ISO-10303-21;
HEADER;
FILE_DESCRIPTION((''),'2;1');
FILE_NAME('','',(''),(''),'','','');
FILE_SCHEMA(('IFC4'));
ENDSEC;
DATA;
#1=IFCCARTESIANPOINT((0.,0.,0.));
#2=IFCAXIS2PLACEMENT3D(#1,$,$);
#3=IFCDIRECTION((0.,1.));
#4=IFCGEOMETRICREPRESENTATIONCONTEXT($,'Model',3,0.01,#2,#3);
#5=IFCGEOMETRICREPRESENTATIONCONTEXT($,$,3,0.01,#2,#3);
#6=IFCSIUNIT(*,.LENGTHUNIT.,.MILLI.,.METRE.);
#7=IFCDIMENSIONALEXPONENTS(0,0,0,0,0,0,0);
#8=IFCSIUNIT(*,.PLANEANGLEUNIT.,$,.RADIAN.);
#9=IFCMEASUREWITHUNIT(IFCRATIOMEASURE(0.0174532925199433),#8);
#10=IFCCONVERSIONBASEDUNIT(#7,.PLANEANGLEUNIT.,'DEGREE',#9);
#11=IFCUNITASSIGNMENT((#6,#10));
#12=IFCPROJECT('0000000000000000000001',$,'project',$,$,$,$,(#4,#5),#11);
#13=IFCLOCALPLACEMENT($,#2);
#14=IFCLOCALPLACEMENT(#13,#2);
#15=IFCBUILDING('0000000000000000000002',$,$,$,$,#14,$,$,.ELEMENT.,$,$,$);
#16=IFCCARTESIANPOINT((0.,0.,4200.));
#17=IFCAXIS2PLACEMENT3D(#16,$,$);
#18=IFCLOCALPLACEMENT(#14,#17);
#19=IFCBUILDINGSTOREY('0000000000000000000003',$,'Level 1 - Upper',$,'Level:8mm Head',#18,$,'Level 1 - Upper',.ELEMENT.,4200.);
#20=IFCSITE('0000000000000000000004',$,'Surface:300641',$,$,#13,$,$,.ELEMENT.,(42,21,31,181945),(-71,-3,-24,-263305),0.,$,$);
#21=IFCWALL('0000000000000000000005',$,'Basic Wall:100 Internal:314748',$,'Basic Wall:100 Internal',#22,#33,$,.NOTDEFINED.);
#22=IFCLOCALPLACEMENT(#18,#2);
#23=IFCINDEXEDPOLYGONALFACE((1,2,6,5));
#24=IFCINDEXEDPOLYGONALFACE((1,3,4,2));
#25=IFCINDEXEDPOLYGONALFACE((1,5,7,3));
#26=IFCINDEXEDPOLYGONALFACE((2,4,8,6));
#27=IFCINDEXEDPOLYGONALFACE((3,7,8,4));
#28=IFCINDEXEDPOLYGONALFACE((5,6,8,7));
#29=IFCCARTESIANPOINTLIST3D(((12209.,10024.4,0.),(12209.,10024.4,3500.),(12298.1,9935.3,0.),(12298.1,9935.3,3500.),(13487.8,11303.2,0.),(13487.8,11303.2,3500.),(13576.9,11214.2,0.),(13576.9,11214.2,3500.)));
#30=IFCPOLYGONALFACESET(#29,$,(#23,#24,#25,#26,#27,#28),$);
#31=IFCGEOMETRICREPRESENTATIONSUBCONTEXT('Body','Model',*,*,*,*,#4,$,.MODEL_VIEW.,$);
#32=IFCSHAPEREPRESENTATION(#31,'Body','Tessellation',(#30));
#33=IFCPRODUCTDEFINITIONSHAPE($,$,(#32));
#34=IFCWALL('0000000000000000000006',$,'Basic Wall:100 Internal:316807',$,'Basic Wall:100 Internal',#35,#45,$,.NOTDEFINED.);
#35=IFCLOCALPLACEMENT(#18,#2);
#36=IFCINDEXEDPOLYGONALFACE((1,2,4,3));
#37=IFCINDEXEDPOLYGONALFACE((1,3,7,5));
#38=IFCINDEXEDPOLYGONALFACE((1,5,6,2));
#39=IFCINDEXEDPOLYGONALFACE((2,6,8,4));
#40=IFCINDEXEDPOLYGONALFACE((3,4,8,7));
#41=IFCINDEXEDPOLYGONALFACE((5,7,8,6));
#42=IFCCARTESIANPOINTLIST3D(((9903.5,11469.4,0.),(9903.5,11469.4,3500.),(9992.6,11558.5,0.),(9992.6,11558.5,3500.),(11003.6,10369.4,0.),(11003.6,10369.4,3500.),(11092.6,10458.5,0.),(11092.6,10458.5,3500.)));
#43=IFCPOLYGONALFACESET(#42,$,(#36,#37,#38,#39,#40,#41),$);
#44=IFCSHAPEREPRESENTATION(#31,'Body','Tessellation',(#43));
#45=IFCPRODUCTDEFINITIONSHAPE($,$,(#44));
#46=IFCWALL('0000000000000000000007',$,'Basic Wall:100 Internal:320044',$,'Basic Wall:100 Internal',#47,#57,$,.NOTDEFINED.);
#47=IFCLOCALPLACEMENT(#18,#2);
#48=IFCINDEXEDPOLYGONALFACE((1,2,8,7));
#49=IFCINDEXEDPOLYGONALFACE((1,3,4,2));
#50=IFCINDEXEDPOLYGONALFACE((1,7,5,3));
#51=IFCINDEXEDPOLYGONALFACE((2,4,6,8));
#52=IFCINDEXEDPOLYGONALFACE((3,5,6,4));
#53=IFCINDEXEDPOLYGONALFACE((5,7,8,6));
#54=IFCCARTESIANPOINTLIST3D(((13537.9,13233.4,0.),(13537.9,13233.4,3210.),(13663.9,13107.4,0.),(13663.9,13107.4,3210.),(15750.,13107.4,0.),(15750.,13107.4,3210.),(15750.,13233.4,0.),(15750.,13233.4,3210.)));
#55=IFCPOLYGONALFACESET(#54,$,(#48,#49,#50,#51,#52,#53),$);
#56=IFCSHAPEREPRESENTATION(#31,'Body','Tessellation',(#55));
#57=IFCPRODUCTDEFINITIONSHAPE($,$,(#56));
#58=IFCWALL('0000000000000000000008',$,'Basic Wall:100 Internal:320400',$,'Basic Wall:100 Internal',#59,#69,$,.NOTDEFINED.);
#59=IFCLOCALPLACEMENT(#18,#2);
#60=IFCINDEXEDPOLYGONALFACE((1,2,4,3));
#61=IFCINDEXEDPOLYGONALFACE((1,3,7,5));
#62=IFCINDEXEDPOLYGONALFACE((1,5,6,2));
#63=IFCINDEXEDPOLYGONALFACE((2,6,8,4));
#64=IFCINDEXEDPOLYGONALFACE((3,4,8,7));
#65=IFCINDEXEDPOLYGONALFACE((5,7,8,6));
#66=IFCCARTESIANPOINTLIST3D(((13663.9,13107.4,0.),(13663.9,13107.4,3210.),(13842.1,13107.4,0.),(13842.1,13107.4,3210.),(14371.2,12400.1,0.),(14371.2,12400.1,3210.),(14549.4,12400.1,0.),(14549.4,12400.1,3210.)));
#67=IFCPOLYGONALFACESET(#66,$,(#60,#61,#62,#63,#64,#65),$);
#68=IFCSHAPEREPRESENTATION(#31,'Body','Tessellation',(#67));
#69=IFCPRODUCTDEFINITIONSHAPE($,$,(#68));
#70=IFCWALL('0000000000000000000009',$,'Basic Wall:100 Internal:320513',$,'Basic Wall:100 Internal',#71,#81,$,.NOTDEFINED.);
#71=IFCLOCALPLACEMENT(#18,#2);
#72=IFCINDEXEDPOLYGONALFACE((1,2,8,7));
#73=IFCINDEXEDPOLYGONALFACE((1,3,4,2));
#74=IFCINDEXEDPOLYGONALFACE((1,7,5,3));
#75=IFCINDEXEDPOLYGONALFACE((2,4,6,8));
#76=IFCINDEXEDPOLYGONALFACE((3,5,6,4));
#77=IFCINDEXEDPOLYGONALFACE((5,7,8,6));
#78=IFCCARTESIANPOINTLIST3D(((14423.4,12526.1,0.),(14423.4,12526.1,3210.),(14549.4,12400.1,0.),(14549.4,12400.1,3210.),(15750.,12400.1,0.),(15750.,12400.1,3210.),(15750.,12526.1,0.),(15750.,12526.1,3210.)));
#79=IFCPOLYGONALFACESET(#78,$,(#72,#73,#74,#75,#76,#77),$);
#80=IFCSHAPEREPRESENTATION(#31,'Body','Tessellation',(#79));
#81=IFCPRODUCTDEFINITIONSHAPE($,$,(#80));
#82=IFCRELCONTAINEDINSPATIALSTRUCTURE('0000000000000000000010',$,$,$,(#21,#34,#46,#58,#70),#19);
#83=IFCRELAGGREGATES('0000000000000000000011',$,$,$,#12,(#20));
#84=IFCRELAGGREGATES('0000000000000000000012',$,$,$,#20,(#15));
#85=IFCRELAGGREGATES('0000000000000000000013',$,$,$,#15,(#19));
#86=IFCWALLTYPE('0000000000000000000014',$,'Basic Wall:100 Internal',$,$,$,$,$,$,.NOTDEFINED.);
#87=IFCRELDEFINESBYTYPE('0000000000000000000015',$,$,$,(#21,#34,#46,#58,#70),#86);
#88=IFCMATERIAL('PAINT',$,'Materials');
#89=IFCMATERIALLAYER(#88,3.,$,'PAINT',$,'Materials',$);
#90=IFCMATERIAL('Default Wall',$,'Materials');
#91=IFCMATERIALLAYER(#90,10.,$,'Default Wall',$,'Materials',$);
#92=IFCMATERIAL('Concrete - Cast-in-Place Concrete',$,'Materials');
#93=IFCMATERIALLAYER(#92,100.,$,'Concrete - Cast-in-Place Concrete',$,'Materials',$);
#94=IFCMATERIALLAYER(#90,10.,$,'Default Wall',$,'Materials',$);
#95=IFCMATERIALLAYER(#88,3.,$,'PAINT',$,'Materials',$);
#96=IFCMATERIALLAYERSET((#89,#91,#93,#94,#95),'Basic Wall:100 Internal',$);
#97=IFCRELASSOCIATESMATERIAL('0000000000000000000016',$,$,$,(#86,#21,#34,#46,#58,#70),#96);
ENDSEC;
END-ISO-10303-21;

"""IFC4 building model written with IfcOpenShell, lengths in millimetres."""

from ifc_helpers import new_model, entity, si_unit, converted_unit, direction, frame, frame_2d, origin, place, context, subcontext, project, spatial, polyline, rectangle, outline, extrude, clip, halfspace, bounded_halfspace, material, layer, layer_set, layer_usage, type_object, element, save


model = new_model("IFC4")

# Units and contexts
model_context = context("Model", 3, precision=0.01, world=origin(), true_north=direction((0.0, 1.0)))
context_of_model = context(None, 3, precision=0.01, world=origin(), true_north=direction((0.0, 1.0)))
body_context = subcontext(model_context, "Body", "Model", "MODEL_VIEW")
ifc_project = project(units=[si_unit("LENGTHUNIT", "METRE", prefix="MILLI"), converted_unit("PLANEANGLEUNIT", "DEGREE", entity("IfcRatioMeasure", 0.0174532925199433), si_unit("PLANEANGLEUNIT", "RADIAN"), dimensions=[0, 0, 0, 0, 0, 0, 0])], contexts=[model_context, context_of_model])

# Site, building, storey
site_placement = place(None, origin())
site = spatial("IfcSite", under=ifc_project, at=site_placement, Name="Surface:300641", CompositionType="ELEMENT", RefLatitude=(42, 21, 31, 181945), RefLongitude=(-71, -3, -24, -263305), RefElevation=0.0)
building_placement = place(site_placement, origin())
building = spatial("IfcBuilding", under=site, at=building_placement, CompositionType="ELEMENT")
storey_placement = place(building_placement, frame((0.0, 0.0, 4200.0)))
storey = spatial("IfcBuildingStorey", under=building, at=storey_placement, Name="Level 1 - Upper", ObjectType="Level:8mm Head", LongName="Level 1 - Upper", CompositionType="ELEMENT", Elevation=4200.0)

# Shared definitions
ifc_material_1 = material(Name="PAINT", Category="Materials")
ifc_material_2 = material(Name="Concrete - Cast-in-Place Concrete", Category="Materials")
ifc_material_3 = material(Name="Default Wall", Category="Materials")

# Walls
ifc_layer_1 = layer(ifc_material_1, 3.0, Name="PAINT", Category="Materials")
ifc_layer_2 = layer(ifc_material_3, 10.0, Name="Default Wall", Category="Materials")
ifc_layer_3 = layer(ifc_material_2, 100.0, Name="Concrete - Cast-in-Place Concrete", Category="Materials")
ifc_layer_4 = layer(ifc_material_3, 10.0, Name="Default Wall", Category="Materials")
ifc_layer_5 = layer(ifc_material_1, 3.0, Name="PAINT", Category="Materials")
ifc_layer_set_1 = layer_set([ifc_layer_1, ifc_layer_2, ifc_layer_3, ifc_layer_4, ifc_layer_5], Name="Basic Wall:100 Internal")
ifc_layer_usage_1 = layer_usage(ifc_layer_set_1, "AXIS2", "NEGATIVE", 63.0)
wall_type_1 = type_object("IfcWallType", Name="Basic Wall:100 Internal", PredefinedType="NOTDEFINED", material=ifc_layer_set_1)
wall_1_placement = place(storey_placement, frame((13532.4, 11258.7, 0.0), z_axis=(0.0, 0.0, 1.0), x_axis=(-0.707107, -0.707107, 0.0)))
element("IfcWall", 1, at=wall_1_placement, inside=storey, type_object=wall_type_1, material=ifc_layer_usage_1, Name="Basic Wall:100 Internal:314748", ObjectType="Basic Wall:100 Internal", PredefinedType="NOTDEFINED", context=body_context, shape_type="Clipping", body=[
    clip(extrude(rectangle(XDim=1808.6, YDim=126.0, at=frame_2d((904.3, 0.0), x_axis=(-1.0, 0.0))), origin(), (0.0, 0.0, 1.0), 3500.0), halfspace(origin(), True)),
])
ifc_layer_usage_2 = layer_usage(ifc_layer_set_1, "AXIS2", "NEGATIVE", 63.0)
wall_2_placement = place(storey_placement, frame((9948.0, 11514.0, 0.0), z_axis=(0.0, 0.0, 1.0), x_axis=(0.707107, -0.707107, 0.0)))
element("IfcWall", 2, at=wall_2_placement, inside=storey, type_object=wall_type_1, material=ifc_layer_usage_2, Name="Basic Wall:100 Internal:316807", ObjectType="Basic Wall:100 Internal", PredefinedType="NOTDEFINED", context=body_context, shape_type="Clipping", body=[
    clip(extrude(rectangle(XDim=1555.7, YDim=126.0, at=frame_2d((777.9, 0.0), x_axis=(-1.0, 0.0))), origin(), (0.0, 0.0, 1.0), 3500.0), halfspace(origin(), True)),
])

# Walls
ifc_layer_usage_3 = layer_usage(ifc_layer_set_1, "AXIS2", "NEGATIVE", 63.0)
wall_3_placement = place(storey_placement, frame((15750.0, 13170.4, 0.0), z_axis=(0.0, 0.0, 1.0), x_axis=(-1.0, 0.0, 0.0)))
element("IfcWall", 3, at=wall_3_placement, inside=storey, type_object=wall_type_1, material=ifc_layer_usage_3, Name="Basic Wall:100 Internal:320044", ObjectType="Basic Wall:100 Internal", PredefinedType="NOTDEFINED", context=body_context, shape_type="Clipping", body=[
    clip(clip(extrude(outline(polyline([(2212.1, -63.0), (2086.1, 63.0), (1907.9, 63.0), (0.0, 63.0), (0.0, -63.0), (2212.1, -63.0)])), origin(), (0.0, 0.0, 1.0), 3210.0), bounded_halfspace(frame((0.0, -63.0, 3210.0), z_axis=(0.0, 0.0, -1.0), x_axis=(0.0, 1.0, 0.0)), True, frame((0.0, -63.0, 3210.0)), polyline([(0.0, 0.0), (2212.1, 0.0), (2086.1, 126.0), (1907.9, 126.0), (0.0, 126.0), (0.0, 0.0)]))), halfspace(frame((0.0, 0.0, -400.0)), True)),
])
ifc_layer_usage_4 = layer_usage(ifc_layer_set_1, "AXIS2", "NEGATIVE", 63.0)
wall_4_placement = place(storey_placement, frame((13708.5, 13152.0, 0.0), z_axis=(0.0, 0.0, 1.0), x_axis=(0.707107, -0.707107, 0.0)))
element("IfcWall", 4, at=wall_4_placement, inside=storey, type_object=wall_type_1, material=ifc_layer_usage_4, Name="Basic Wall:100 Internal:320400", ObjectType="Basic Wall:100 Internal", PredefinedType="NOTDEFINED", context=body_context, shape_type="Clipping", body=[
    clip(clip(extrude(outline(polyline([(1000.3, -63.0), (1126.3, 63.0), (948.1, 63.0), (126.0, 63.0), (0.0, -63.0), (1000.3, -63.0)])), origin(), (0.0, 0.0, 1.0), 3210.0), bounded_halfspace(frame((0.0, -63.0, 3210.0), z_axis=(0.0, 0.0, -1.0), x_axis=(0.707107, -0.707107, 0.0)), True, frame((0.0, -63.0, 3210.0)), polyline([(0.0, 0.0), (1000.3, 0.0), (1126.3, 126.0), (948.1, 126.0), (126.0, 126.0), (0.0, 0.0)]))), halfspace(frame((0.0, 0.0, -400.0)), True)),
])
ifc_layer_usage_5 = layer_usage(ifc_layer_set_1, "AXIS2", "NEGATIVE", 63.0)
wall_5_placement = place(storey_placement, frame((14423.4, 12463.1, 0.0)))
element("IfcWall", 5, at=wall_5_placement, inside=storey, type_object=wall_type_1, material=ifc_layer_usage_5, Name="Basic Wall:100 Internal:320513", ObjectType="Basic Wall:100 Internal", PredefinedType="NOTDEFINED", context=body_context, shape_type="Clipping", body=[
    clip(clip(extrude(outline(polyline([(1326.6, -63.0), (1326.6, 63.0), (0.0, 63.0), (126.0, -63.0), (1326.6, -63.0)])), origin(), (0.0, 0.0, 1.0), 3210.0), bounded_halfspace(frame((126.0, -63.0, 3210.0), z_axis=(0.0, 0.0, -1.0), x_axis=(0.0, -1.0, 0.0)), True, frame((126.0, -63.0, 3210.0)), polyline([(0.0, 0.0), (1200.6, 0.0), (1200.6, 126.0), (-126.0, 126.0), (0.0, 0.0)]))), halfspace(frame((0.0, 0.0, -400.0)), True)),
])

save(model, "model.ifc")
